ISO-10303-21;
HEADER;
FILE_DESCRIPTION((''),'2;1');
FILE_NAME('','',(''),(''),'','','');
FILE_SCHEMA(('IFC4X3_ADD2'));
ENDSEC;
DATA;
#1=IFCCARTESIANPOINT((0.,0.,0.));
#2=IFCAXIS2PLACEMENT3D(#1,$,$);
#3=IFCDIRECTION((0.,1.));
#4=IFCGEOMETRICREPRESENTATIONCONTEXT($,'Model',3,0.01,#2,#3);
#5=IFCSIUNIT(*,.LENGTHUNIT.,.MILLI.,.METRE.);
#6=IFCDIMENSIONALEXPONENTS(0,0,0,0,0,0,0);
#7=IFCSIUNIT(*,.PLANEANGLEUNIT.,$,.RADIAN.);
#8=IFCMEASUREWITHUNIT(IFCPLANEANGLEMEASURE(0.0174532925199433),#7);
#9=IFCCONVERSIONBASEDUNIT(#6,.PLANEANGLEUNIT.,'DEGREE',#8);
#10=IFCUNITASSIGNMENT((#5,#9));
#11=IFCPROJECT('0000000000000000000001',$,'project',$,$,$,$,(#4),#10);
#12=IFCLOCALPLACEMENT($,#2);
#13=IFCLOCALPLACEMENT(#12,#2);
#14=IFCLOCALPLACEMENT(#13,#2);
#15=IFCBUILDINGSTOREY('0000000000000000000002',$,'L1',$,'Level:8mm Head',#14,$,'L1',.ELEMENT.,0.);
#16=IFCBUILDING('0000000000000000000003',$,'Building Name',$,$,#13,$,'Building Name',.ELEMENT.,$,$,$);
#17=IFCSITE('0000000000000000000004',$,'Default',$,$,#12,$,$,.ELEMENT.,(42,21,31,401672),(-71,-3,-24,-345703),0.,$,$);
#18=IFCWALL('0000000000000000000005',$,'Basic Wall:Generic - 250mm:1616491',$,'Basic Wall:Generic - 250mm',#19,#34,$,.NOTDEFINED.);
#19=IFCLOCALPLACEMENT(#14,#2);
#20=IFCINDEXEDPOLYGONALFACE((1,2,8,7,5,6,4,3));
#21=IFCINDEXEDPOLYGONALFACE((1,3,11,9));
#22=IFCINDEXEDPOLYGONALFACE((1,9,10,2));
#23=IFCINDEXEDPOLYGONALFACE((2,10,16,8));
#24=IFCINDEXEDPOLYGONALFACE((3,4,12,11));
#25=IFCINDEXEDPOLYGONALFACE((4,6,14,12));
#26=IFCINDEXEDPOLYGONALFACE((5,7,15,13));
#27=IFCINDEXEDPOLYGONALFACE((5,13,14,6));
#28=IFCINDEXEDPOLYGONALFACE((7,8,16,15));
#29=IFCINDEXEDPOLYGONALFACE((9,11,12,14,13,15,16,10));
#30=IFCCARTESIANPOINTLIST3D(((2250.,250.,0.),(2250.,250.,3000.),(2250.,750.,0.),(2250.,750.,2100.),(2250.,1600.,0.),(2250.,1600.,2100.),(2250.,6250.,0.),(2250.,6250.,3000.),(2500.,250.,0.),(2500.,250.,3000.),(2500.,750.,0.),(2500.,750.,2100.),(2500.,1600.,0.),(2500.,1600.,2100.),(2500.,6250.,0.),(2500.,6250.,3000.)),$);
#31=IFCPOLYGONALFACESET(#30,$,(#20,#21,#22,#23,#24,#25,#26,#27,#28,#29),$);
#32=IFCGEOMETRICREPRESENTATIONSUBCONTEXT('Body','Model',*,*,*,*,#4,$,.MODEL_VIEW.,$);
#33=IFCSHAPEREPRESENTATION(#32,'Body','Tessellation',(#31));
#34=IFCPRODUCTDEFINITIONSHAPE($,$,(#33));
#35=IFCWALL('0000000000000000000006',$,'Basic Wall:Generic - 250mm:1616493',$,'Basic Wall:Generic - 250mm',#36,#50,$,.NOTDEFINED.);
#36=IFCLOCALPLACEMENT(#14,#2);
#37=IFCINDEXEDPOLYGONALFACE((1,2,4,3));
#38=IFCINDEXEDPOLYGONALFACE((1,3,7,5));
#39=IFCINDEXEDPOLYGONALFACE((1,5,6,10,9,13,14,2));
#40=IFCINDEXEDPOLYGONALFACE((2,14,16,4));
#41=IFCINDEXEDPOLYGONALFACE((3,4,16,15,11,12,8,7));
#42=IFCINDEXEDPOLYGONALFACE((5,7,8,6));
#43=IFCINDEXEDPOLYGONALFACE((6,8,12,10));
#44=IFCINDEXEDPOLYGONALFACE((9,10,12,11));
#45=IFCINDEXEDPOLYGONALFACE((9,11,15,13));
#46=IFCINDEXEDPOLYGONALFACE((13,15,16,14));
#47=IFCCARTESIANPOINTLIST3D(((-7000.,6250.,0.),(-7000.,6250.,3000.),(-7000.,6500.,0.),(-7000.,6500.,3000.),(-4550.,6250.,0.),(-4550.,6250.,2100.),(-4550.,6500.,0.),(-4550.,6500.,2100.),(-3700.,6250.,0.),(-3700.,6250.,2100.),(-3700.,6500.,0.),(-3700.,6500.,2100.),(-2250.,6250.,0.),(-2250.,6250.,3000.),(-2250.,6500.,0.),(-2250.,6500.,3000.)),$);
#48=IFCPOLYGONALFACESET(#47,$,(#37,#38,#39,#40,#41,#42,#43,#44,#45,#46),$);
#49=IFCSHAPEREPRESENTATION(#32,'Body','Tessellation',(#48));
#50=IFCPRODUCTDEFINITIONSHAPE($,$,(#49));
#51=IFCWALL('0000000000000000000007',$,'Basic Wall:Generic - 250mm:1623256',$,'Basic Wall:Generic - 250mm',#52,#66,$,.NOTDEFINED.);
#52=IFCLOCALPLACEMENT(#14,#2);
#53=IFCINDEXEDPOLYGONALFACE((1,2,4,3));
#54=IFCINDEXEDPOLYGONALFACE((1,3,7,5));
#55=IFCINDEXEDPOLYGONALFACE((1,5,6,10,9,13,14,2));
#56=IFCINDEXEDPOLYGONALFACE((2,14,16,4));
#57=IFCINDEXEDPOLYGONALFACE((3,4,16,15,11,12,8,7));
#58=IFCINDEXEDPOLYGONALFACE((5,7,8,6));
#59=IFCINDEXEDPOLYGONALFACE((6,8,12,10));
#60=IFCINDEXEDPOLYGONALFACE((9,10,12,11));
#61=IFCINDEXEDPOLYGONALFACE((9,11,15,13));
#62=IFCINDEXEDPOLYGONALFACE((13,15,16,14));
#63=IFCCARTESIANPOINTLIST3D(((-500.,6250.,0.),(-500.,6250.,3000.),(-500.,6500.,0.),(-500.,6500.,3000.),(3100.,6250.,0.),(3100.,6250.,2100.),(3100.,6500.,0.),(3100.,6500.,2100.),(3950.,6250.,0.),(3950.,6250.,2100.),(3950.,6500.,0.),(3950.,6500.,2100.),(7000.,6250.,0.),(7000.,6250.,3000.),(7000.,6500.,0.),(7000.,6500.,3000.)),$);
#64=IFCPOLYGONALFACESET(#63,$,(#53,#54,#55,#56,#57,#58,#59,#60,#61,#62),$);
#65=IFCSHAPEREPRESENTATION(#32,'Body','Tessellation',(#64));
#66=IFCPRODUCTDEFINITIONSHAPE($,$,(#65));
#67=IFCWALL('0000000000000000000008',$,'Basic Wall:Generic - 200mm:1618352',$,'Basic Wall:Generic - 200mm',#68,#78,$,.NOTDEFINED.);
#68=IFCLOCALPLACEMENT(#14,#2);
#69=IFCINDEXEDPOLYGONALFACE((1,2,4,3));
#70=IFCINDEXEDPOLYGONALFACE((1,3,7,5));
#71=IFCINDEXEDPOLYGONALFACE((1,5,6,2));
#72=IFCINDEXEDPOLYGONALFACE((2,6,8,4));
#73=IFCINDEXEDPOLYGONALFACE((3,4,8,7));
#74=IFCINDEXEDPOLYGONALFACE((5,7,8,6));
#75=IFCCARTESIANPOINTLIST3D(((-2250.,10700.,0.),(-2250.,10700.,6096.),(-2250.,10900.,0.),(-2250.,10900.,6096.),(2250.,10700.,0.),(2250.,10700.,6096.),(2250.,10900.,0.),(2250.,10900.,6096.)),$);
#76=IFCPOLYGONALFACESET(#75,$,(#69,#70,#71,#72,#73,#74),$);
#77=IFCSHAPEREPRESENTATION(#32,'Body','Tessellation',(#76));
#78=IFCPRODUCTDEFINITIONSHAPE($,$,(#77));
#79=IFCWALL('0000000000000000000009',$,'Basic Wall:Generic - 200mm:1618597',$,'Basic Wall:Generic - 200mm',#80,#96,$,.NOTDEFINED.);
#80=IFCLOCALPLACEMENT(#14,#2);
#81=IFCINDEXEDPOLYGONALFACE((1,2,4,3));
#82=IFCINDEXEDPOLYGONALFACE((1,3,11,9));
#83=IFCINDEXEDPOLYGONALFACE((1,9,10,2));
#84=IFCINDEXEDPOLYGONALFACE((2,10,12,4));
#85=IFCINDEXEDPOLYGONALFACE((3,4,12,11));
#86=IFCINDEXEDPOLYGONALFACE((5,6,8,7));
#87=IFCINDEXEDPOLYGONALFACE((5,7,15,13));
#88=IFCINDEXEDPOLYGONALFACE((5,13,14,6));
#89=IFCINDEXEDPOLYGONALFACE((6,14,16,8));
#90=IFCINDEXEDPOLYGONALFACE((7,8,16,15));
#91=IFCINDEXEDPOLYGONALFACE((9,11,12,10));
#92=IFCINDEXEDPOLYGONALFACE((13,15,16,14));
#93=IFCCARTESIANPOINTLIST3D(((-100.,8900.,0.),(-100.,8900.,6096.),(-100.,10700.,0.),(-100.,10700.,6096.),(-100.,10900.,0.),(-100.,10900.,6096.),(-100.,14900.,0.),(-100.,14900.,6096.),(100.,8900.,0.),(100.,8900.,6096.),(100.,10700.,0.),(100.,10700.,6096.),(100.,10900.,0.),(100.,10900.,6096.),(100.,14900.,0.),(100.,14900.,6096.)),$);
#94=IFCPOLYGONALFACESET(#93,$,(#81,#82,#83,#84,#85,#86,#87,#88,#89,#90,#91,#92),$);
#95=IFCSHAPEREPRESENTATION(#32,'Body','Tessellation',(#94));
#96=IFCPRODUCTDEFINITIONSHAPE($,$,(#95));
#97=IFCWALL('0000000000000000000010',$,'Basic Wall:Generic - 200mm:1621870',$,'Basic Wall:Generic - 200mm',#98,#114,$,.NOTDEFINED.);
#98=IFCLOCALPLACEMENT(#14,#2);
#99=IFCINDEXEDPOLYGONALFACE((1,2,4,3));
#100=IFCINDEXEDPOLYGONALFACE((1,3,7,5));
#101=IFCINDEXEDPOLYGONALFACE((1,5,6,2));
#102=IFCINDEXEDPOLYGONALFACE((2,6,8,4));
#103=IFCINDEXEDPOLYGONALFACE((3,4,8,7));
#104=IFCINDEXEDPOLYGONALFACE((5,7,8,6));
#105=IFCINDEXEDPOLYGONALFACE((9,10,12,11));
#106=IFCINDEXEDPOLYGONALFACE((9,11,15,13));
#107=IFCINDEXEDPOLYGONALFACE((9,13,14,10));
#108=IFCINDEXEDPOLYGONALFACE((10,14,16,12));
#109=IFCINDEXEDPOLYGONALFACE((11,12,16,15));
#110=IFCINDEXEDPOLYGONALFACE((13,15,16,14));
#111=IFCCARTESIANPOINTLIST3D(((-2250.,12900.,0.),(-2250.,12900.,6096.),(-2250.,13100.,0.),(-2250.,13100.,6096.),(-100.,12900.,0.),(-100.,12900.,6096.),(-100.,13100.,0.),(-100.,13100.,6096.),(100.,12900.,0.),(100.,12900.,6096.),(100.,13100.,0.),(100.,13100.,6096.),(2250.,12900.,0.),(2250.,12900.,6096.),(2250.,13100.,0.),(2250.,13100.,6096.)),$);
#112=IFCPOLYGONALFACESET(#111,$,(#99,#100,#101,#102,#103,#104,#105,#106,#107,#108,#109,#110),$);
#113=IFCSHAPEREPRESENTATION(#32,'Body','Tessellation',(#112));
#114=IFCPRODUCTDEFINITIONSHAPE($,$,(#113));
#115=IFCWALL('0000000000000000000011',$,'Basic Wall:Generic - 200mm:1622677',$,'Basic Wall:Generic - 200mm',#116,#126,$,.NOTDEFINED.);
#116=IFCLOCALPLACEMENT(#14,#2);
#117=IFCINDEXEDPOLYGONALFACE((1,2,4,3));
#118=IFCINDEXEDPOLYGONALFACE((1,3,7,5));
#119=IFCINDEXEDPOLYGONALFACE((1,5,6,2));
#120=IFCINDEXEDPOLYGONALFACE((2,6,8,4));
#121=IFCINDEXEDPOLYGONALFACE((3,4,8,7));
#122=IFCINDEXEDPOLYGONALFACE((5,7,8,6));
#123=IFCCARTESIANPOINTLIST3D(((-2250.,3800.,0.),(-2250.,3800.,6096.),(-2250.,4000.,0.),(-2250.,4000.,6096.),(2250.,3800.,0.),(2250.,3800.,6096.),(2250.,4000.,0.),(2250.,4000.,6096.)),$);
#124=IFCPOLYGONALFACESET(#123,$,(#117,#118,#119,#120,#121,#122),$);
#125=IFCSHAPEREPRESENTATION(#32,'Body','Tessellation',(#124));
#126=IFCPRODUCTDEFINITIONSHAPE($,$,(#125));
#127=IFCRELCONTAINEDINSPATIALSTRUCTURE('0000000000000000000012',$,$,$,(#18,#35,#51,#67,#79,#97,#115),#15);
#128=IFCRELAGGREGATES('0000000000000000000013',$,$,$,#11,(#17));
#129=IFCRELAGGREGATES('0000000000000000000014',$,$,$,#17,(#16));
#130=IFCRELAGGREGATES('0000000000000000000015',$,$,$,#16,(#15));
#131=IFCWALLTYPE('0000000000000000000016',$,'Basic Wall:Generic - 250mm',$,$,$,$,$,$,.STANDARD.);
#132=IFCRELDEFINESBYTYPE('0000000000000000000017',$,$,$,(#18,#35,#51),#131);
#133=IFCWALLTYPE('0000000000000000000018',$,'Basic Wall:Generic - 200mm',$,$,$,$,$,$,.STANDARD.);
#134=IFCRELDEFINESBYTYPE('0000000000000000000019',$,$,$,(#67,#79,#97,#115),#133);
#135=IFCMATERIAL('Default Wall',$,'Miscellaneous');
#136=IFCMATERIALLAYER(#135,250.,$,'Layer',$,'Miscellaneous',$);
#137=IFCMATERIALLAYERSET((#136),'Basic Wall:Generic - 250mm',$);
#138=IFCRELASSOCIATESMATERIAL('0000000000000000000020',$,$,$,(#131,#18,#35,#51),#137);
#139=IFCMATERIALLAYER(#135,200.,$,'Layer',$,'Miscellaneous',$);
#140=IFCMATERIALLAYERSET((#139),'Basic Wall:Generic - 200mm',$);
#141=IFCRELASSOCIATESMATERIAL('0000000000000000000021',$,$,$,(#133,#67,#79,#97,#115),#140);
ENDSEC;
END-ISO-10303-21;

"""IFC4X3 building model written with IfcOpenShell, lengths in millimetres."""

from ifc_helpers import new_model, entity, si_unit, converted_unit, direction, frame, frame_2d, origin, place, context, subcontext, project, spatial, rectangle, extrude, material, layer, layer_set, type_object, element, save


model = new_model("IFC4X3")

# Units and contexts
model_context = context("Model", 3, precision=0.01, world=origin(), true_north=direction((0.0, 1.0)))
body_context = subcontext(model_context, "Body", "Model", "MODEL_VIEW")
ifc_project = project(units=[si_unit("LENGTHUNIT", "METRE", prefix="MILLI"), converted_unit("PLANEANGLEUNIT", "DEGREE", entity("IfcPlaneAngleMeasure", 0.0174532925199433), si_unit("PLANEANGLEUNIT", "RADIAN"), dimensions=[0, 0, 0, 0, 0, 0, 0])], contexts=[model_context])

# Site, building, storey
site_placement = place(None, origin())
site = spatial("IfcSite", under=ifc_project, at=site_placement, Name="Default", CompositionType="ELEMENT", RefLatitude=(42, 21, 31, 401672), RefLongitude=(-71, -3, -24, -345703), RefElevation=0.0)
building_placement = place(site_placement, origin())
building = spatial("IfcBuilding", under=site, at=building_placement, Name="Building Name", LongName="Building Name", CompositionType="ELEMENT")
storey_placement = place(building_placement, origin())
storey = spatial("IfcBuildingStorey", under=building, at=storey_placement, Name="L1", ObjectType="Level:8mm Head", LongName="L1", CompositionType="ELEMENT", Elevation=0.0)

# Shared definitions
ifc_material = material(Name="Default Wall", Category="Miscellaneous")
ifc_layer_1 = layer(ifc_material, 250.0, Name="Layer", Category="Miscellaneous")
ifc_layer_set_1 = layer_set([ifc_layer_1], Name="Basic Wall:Generic - 250mm")
wall_type_1 = type_object("IfcWallType", Name="Basic Wall:Generic - 250mm", PredefinedType="STANDARD", material=ifc_layer_set_1)

# Walls, openings
wall_1_placement = place(storey_placement, frame((2375.0, 250.0, 0.0), z_axis=(0.0, 0.0, 1.0), x_axis=(0.0, 1.0, 0.0)))
wall_1 = element("IfcWall", 1, at=wall_1_placement, inside=storey, type_object=wall_type_1, material=ifc_layer_set_1, Name="Basic Wall:Generic - 250mm:1616491", ObjectType="Basic Wall:Generic - 250mm", PredefinedType="NOTDEFINED", context=body_context, shape_type="SweptSolid", body=[
    extrude(rectangle(XDim=6000.0, YDim=250.0, at=frame_2d((3000.0, 0.0), x_axis=(-1.0, 0.0))), origin(), (0.0, 0.0, 1.0), 3000.0),
])
opening_1_placement = place(wall_1_placement, frame((500.0, -125.0, 0.0)))
element("IfcOpeningElement", 2, at=opening_1_placement, cuts=wall_1, PredefinedType="OPENING", context=body_context, shape_type="SweptSolid", body=[
    extrude(rectangle(XDim=2100.0, YDim=850.0, at=frame_2d((1050.0, 425.0), x_axis=(1.0, 0.0))), frame((0.0, 0.0, 0.0), z_axis=(0.0, 1.0, 0.0), x_axis=(0.0, 0.0, 1.0)), (0.0, 0.0, 1.0), 250.0),
])
wall_2_placement = place(storey_placement, frame((-7000.0, 6375.0, 0.0)))
wall_2 = element("IfcWall", 3, at=wall_2_placement, inside=storey, type_object=wall_type_1, material=ifc_layer_set_1, Name="Basic Wall:Generic - 250mm:1616493", ObjectType="Basic Wall:Generic - 250mm", PredefinedType="NOTDEFINED", context=body_context, shape_type="SweptSolid", body=[
    extrude(rectangle(XDim=4750.0, YDim=250.0, at=frame_2d((2375.0, 0.0), x_axis=(1.0, 0.0))), origin(), (0.0, 0.0, 1.0), 3000.0),
])
opening_2_placement = place(wall_2_placement, frame((3300.0, 125.0, 0.0)))
element("IfcOpeningElement", 4, at=opening_2_placement, cuts=wall_2, PredefinedType="OPENING", context=body_context, shape_type="SweptSolid", body=[
    extrude(rectangle(XDim=2100.0, YDim=850.0, at=frame_2d((1050.0, 425.0), x_axis=(1.0, 0.0))), frame((0.0, 0.0, 0.0), z_axis=(0.0, -1.0, 0.0), x_axis=(0.0, 0.0, 1.0)), (0.0, 0.0, 1.0), 250.0),
])

# Wall, openings
wall_3_placement = place(storey_placement, frame((-500.0, 6375.0, 0.0)))
wall_3 = element("IfcWall", 5, at=wall_3_placement, inside=storey, type_object=wall_type_1, material=ifc_layer_set_1, Name="Basic Wall:Generic - 250mm:1623256", ObjectType="Basic Wall:Generic - 250mm", PredefinedType="NOTDEFINED", context=body_context, shape_type="SweptSolid", body=[
    extrude(rectangle(XDim=7500.0, YDim=250.0, at=frame_2d((3750.0, 0.0), x_axis=(1.0, 0.0))), origin(), (0.0, 0.0, 1.0), 3000.0),
])
opening_3_placement = place(wall_3_placement, frame((4450.0, 125.0, 0.0)))
element("IfcOpeningElement", 6, at=opening_3_placement, cuts=wall_3, PredefinedType="OPENING", context=body_context, shape_type="SweptSolid", body=[
    extrude(rectangle(XDim=2100.0, YDim=850.0, at=frame_2d((1050.0, 425.0), x_axis=(1.0, 0.0))), frame((0.0, 0.0, 0.0), z_axis=(0.0, -1.0, 0.0), x_axis=(0.0, 0.0, 1.0)), (0.0, 0.0, 1.0), 250.0),
])
opening_4_placement = place(wall_3_placement, frame((500.0, -6375.0, 0.0)))
element("IfcOpeningElement", 7, at=opening_4_placement, cuts=wall_3, PredefinedType="OPENING", context=body_context, shape_type="SweptSolid", body=[
    extrude(rectangle(XDim=2100.0, YDim=850.0, at=frame_2d((0.0, 0.0), x_axis=(1.0, 0.0))), frame((3525.0, 4976.0, 1050.0), z_axis=(0.0, 1.0, 0.0), x_axis=(0.0, 0.0, 1.0)), (0.0, 0.0, 1.0), 3048.0),
])

# Wall
ifc_layer_2 = layer(ifc_material, 200.0, Name="Layer", Category="Miscellaneous")
ifc_layer_set_2 = layer_set([ifc_layer_2], Name="Basic Wall:Generic - 200mm")
wall_type_2 = type_object("IfcWallType", Name="Basic Wall:Generic - 200mm", PredefinedType="STANDARD", material=ifc_layer_set_2)
wall_4_placement = place(storey_placement, frame((-2250.0, 10800.0, 0.0)))
element("IfcWall", 8, at=wall_4_placement, inside=storey, type_object=wall_type_2, material=ifc_layer_set_2, Name="Basic Wall:Generic - 200mm:1618352", ObjectType="Basic Wall:Generic - 200mm", PredefinedType="NOTDEFINED", context=body_context, shape_type="SweptSolid", body=[
    extrude(rectangle(XDim=4500.0, YDim=200.0, at=frame_2d((2250.0, 0.0), x_axis=(-1.0, 0.0))), origin(), (0.0, 0.0, 1.0), 6096.0),
])

# Walls, openings
wall_5_placement = place(storey_placement, frame((0.0, 8900.0, 0.0), z_axis=(0.0, 0.0, 1.0), x_axis=(0.0, 1.0, 0.0)))
wall_5 = element("IfcWall", 9, at=wall_5_placement, inside=storey, type_object=wall_type_2, material=ifc_layer_set_2, Name="Basic Wall:Generic - 200mm:1618597", ObjectType="Basic Wall:Generic - 200mm", PredefinedType="NOTDEFINED", context=body_context, shape_type="SweptSolid", body=[
    extrude(rectangle(XDim=6000.0, YDim=200.0, at=frame_2d((3000.0, 0.0), x_axis=(-1.0, 0.0))), origin(), (0.0, 0.0, 1.0), 6096.0),
])
opening_5_placement = place(storey_placement, frame((0.0, 8900.0, 0.0), z_axis=(0.0, 0.0, 1.0), x_axis=(0.0, 1.0, 0.0)))
element("IfcOpeningElement", 10, at=opening_5_placement, cuts=wall_5, PredefinedType="OPENING", context=body_context, shape_type="SweptSolid", body=[
    extrude(rectangle(XDim=6096.0, YDim=200.0, at=frame_2d((0.0, 0.0), x_axis=(1.0, 0.0))), frame((1800.0, 0.0, 3048.0), z_axis=(1.0, 0.0, 0.0), x_axis=(0.0, 0.0, -1.0)), (0.0, 0.0, 1.0), 200.0),
])
wall_6_placement = place(storey_placement, frame((-2250.0, 13000.0, 0.0)))
wall_6 = element("IfcWall", 11, at=wall_6_placement, inside=storey, type_object=wall_type_2, material=ifc_layer_set_2, Name="Basic Wall:Generic - 200mm:1621870", ObjectType="Basic Wall:Generic - 200mm", PredefinedType="NOTDEFINED", context=body_context, shape_type="SweptSolid", body=[
    extrude(rectangle(XDim=4500.0, YDim=200.0, at=frame_2d((2250.0, 0.0), x_axis=(-1.0, 0.0))), origin(), (0.0, 0.0, 1.0), 6096.0),
])
opening_6_placement = place(storey_placement, frame((-2250.0, 13000.0, 0.0)))
element("IfcOpeningElement", 12, at=opening_6_placement, cuts=wall_6, PredefinedType="OPENING", context=body_context, shape_type="SweptSolid", body=[
    extrude(rectangle(XDim=6096.0, YDim=200.0, at=frame_2d((0.0, 0.0), x_axis=(1.0, 0.0))), frame((2150.0, 0.0, 3048.0), z_axis=(1.0, 0.0, 0.0), x_axis=(0.0, 0.0, -1.0)), (0.0, 0.0, 1.0), 200.0),
])

# Wall
wall_7_placement = place(storey_placement, frame((-2250.0, 3900.0, 0.0)))
element("IfcWall", 13, at=wall_7_placement, inside=storey, type_object=wall_type_2, material=ifc_layer_set_2, Name="Basic Wall:Generic - 200mm:1622677", ObjectType="Basic Wall:Generic - 200mm", PredefinedType="NOTDEFINED", context=body_context, shape_type="SweptSolid", body=[
    extrude(rectangle(XDim=4500.0, YDim=200.0, at=frame_2d((2250.0, 0.0), x_axis=(-1.0, 0.0))), origin(), (0.0, 0.0, 1.0), 6096.0),
])

save(model, "model.ifc")
